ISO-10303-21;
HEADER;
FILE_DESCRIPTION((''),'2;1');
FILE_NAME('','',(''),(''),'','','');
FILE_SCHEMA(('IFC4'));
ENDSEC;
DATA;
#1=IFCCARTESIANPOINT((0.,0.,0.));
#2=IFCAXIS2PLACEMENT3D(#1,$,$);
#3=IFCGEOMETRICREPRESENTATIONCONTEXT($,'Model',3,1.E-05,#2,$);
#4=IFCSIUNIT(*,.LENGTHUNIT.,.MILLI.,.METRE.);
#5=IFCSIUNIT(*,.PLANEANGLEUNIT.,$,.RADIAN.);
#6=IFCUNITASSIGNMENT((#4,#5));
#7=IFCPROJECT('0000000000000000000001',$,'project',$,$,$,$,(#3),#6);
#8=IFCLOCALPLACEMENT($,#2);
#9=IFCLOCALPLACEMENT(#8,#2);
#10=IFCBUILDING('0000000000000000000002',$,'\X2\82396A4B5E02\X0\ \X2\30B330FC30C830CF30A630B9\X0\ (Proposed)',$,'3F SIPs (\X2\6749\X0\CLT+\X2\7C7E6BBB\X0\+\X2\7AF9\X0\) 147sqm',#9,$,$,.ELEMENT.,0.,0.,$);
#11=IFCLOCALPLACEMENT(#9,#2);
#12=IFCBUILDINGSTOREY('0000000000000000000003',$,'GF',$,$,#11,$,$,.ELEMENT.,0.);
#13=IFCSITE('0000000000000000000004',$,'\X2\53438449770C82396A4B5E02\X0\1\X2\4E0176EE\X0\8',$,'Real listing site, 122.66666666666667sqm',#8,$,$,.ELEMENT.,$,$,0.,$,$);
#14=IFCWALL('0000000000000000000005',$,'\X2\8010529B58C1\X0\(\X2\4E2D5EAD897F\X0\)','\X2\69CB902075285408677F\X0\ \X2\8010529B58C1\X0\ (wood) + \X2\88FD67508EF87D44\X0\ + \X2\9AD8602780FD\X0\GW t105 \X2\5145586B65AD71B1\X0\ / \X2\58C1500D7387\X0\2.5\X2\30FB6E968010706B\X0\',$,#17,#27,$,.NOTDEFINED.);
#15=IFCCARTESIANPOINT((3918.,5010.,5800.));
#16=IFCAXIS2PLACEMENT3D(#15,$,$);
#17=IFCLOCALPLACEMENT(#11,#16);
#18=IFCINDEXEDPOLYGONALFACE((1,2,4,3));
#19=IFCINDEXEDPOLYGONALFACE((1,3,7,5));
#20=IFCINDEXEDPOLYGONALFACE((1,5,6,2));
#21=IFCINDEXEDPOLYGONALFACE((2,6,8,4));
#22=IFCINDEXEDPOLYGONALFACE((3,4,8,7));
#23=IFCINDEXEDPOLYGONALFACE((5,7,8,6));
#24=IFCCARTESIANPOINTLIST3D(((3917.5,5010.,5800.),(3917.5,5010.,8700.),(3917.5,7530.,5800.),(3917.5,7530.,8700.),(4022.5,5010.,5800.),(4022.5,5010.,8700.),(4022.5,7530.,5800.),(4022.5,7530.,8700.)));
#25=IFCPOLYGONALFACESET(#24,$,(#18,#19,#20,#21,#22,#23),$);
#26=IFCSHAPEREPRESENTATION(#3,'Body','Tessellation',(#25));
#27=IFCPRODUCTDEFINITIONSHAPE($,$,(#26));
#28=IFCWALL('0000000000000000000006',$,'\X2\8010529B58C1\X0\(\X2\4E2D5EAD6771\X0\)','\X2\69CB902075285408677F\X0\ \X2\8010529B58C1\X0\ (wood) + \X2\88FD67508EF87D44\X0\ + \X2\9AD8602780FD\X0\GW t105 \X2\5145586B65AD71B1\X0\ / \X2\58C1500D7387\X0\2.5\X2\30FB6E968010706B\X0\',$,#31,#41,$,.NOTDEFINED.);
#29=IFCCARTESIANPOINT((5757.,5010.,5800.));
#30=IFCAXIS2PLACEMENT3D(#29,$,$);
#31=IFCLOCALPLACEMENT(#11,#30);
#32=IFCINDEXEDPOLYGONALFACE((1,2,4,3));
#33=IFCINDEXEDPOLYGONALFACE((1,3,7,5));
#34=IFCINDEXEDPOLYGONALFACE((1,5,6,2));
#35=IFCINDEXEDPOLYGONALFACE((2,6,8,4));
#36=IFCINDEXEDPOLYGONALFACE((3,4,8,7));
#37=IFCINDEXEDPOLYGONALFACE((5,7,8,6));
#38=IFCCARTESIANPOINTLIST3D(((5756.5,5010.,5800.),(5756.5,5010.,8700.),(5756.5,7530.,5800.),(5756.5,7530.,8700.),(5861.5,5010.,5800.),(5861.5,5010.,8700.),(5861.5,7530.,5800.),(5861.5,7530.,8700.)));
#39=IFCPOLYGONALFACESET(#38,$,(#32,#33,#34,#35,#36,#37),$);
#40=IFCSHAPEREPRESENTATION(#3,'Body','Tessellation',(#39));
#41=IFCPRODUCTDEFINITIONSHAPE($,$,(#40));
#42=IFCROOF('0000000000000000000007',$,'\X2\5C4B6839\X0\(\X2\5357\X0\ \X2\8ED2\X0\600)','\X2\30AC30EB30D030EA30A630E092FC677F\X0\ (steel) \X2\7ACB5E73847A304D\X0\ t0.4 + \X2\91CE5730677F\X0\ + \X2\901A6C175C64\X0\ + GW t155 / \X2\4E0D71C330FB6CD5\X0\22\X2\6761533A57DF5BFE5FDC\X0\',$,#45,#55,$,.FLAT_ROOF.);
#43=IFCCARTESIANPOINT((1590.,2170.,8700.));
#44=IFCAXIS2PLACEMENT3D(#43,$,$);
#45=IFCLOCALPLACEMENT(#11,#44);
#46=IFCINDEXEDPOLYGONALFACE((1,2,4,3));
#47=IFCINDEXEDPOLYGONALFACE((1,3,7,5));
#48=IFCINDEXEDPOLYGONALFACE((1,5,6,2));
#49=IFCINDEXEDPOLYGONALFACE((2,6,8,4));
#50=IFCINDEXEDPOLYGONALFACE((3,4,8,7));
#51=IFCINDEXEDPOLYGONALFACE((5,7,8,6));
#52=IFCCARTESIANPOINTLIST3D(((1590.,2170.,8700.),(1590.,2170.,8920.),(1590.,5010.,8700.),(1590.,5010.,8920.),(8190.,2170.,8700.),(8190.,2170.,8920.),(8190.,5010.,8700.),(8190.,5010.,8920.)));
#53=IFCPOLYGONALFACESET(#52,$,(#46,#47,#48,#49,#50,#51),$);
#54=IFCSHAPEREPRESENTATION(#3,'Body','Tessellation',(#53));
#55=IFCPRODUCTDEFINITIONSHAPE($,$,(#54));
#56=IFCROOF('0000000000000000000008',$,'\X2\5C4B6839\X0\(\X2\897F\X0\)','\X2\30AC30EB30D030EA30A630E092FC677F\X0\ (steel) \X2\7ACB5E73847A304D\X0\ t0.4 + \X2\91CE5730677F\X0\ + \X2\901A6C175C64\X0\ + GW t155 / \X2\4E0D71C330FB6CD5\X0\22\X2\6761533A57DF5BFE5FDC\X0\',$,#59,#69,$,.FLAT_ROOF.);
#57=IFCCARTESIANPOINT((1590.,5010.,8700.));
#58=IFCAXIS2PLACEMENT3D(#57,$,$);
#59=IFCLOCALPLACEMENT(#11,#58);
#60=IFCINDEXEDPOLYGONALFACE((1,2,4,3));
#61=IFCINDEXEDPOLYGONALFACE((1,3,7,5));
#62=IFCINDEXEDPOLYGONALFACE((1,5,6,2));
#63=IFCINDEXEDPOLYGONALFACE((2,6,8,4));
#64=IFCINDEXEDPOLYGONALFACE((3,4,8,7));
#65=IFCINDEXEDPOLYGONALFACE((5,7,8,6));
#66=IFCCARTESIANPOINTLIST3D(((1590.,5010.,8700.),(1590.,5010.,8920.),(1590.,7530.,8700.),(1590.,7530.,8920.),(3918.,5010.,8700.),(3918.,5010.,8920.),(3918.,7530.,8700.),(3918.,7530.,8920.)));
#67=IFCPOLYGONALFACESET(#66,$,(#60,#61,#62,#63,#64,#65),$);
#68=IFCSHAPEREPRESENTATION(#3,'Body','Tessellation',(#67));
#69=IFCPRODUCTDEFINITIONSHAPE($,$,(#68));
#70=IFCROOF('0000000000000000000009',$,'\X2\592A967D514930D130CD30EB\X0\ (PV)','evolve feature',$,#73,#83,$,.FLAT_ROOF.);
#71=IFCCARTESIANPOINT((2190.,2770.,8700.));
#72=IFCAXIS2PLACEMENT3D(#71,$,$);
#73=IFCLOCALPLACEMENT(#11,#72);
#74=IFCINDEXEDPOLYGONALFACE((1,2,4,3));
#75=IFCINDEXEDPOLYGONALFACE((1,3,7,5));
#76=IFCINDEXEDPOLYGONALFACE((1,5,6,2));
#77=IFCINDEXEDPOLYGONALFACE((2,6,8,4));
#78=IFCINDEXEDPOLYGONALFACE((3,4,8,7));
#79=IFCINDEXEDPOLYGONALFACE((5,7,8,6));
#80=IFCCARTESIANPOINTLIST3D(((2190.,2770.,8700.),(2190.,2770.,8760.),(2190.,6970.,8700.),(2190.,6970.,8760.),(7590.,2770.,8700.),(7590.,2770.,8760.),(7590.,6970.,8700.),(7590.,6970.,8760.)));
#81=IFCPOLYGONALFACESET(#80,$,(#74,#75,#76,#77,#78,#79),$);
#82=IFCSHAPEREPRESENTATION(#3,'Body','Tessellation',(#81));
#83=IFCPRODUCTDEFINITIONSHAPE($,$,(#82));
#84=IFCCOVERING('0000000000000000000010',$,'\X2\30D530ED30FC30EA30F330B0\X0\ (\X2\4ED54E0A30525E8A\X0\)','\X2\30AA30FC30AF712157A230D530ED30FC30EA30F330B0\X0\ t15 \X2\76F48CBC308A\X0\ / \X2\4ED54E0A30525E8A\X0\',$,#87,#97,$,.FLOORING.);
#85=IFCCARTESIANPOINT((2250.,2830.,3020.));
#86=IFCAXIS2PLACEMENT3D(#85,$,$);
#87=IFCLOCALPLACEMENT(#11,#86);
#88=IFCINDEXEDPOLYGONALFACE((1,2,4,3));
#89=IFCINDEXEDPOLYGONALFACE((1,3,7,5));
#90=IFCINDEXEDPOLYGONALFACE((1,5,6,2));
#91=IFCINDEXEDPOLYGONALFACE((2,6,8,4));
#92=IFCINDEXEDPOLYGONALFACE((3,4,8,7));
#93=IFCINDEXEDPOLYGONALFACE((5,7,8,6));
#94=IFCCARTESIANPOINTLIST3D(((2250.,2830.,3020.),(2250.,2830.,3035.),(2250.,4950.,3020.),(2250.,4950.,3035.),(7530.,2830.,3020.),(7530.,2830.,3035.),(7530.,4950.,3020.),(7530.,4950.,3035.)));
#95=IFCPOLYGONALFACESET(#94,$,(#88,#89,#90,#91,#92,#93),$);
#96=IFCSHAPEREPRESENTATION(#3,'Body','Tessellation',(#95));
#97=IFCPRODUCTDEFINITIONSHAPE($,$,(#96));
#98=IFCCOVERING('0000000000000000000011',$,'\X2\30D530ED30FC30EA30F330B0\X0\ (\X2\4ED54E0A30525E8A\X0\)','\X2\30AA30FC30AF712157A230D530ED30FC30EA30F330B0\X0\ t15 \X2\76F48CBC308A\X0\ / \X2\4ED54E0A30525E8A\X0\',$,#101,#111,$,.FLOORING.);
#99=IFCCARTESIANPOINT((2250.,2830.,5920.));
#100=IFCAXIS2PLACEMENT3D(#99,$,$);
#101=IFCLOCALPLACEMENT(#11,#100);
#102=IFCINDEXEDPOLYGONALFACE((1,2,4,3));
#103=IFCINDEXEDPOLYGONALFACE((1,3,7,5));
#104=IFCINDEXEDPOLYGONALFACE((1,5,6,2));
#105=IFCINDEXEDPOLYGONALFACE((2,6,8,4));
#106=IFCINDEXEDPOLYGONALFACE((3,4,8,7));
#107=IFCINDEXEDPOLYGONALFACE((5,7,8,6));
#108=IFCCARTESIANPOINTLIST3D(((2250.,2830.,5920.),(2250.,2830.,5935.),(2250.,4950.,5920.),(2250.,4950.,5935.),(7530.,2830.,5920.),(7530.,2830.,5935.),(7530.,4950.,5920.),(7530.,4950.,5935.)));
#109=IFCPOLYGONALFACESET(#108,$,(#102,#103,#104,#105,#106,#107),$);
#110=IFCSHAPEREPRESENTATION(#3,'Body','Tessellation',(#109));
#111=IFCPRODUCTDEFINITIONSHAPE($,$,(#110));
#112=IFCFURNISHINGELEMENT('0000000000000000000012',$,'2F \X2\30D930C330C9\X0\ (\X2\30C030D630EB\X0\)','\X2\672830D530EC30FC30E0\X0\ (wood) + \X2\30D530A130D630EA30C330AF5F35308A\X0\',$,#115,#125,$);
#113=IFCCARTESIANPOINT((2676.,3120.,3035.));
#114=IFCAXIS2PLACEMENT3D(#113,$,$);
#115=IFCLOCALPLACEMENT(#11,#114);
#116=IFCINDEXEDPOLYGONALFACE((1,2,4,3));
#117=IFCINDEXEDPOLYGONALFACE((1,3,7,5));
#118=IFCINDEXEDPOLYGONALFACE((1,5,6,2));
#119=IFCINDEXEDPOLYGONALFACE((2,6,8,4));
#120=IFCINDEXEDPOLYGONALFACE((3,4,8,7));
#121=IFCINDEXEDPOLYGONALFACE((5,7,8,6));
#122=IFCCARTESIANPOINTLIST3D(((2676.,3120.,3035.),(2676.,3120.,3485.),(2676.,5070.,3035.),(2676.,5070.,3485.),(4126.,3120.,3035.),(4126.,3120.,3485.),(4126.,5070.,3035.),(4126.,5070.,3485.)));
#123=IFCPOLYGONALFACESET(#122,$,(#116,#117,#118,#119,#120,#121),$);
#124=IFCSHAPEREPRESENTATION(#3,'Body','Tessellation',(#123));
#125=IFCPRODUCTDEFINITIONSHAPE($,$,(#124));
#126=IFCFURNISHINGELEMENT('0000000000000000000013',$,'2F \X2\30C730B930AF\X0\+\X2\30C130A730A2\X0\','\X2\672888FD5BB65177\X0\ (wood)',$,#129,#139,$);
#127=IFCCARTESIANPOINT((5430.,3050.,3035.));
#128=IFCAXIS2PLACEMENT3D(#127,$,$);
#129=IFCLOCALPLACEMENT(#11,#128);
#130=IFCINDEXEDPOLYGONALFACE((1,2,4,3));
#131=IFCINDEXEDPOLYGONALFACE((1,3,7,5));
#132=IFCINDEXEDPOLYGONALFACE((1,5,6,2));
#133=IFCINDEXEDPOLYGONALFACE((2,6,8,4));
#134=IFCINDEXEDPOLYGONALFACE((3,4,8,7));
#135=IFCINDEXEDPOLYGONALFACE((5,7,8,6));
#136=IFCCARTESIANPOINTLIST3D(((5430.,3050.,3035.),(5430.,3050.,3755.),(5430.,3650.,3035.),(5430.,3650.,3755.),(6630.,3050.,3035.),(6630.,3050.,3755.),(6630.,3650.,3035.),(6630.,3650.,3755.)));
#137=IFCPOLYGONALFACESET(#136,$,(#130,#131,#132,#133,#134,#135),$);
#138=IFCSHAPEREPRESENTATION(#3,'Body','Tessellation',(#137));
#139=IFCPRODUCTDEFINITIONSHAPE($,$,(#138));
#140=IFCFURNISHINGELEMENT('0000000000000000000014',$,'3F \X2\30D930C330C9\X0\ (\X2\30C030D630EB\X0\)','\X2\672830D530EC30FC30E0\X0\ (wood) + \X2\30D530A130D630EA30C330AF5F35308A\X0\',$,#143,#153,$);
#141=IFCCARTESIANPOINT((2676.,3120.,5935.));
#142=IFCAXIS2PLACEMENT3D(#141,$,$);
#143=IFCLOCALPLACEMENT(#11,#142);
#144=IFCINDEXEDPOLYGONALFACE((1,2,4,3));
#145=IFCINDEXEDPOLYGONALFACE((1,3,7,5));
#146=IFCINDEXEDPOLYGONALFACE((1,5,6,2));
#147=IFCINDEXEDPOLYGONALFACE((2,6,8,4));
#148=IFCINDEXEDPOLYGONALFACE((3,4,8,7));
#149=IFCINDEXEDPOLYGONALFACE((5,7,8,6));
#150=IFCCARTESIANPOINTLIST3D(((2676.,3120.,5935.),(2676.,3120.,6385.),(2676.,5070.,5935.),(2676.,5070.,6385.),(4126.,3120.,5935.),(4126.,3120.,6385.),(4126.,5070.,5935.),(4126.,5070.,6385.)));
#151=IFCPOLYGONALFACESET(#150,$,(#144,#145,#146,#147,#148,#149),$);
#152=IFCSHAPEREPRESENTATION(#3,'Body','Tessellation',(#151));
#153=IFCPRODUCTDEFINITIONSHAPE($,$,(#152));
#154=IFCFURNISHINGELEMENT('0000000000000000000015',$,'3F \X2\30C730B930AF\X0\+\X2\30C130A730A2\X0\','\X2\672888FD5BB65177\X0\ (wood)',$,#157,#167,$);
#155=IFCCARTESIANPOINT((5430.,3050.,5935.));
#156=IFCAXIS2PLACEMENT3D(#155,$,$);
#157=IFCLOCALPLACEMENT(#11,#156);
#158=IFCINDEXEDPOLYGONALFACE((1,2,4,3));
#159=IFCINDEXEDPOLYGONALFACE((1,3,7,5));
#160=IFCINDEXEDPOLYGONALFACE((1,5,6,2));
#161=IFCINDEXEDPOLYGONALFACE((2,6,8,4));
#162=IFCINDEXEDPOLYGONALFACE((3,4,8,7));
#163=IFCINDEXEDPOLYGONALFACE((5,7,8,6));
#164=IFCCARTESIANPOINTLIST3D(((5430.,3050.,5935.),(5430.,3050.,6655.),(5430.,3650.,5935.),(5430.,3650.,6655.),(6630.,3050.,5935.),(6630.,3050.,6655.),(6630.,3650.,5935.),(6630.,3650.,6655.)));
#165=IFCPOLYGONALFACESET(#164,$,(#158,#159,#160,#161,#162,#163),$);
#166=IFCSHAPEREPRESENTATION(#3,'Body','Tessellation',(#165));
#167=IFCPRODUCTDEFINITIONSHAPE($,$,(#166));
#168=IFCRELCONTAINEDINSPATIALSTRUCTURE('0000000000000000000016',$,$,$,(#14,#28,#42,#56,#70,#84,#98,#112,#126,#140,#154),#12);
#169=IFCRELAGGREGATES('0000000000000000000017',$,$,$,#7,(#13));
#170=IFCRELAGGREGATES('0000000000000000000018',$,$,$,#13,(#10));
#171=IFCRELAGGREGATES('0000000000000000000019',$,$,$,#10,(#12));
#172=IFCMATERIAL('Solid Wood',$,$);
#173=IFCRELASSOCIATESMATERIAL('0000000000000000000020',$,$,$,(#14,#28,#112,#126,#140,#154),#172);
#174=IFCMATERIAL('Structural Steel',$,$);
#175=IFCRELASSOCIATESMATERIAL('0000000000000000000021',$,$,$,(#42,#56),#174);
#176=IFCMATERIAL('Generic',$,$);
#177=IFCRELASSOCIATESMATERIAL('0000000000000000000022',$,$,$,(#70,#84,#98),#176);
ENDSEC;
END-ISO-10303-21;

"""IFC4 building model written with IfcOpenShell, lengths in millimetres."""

from ifc_helpers import new_model, si_unit, frame, frame_2d, origin, place, context, project, spatial, rectangle, extrude, material, element, save


model = new_model("IFC4")

# Units and contexts
model_context = context("Model", 3, precision=1e-05, world=origin())
ifc_project = project(units=[si_unit("LENGTHUNIT", "METRE", prefix="MILLI"), si_unit("PLANEANGLEUNIT", "RADIAN")], contexts=[model_context])

# Site, building, storey
site_placement = place(None, origin())
site = spatial("IfcSite", under=ifc_project, at=site_placement, Name="千葉県船橋市1丁目8", ObjectType="Real listing site, 122.66666666666667sqm", CompositionType="ELEMENT", RefElevation=0.0)
building_placement = place(site_placement, origin())
building = spatial("IfcBuilding", under=site, at=building_placement, Name="船橋市 コートハウス (Proposed)", ObjectType="3F SIPs (杉CLT+籾殻+竹) 147sqm", CompositionType="ELEMENT", ElevationOfRefHeight=0.0, ElevationOfTerrain=0.0)
storey_placement = place(building_placement, origin())
storey = spatial("IfcBuildingStorey", under=building, at=storey_placement, Name="GF", CompositionType="ELEMENT", Elevation=0.0)

# Shared definitions
ifc_material_1 = material(Name="Solid Wood")

# Walls
wall_1_placement = place(storey_placement, frame((3918.0, 5010.0, 5800.0)))
element("IfcWall", 1, at=wall_1_placement, inside=storey, material=ifc_material_1, Name="耐力壁(中庭西)", Description="構造用合板 耐力壁 (wood) + 製材軸組 + 高性能GW t105 充填断熱 / 壁倍率2.5・準耐火", PredefinedType="NOTDEFINED", context=model_context, shape_type="SweptSolid", body=[
    extrude(rectangle(XDim=105.0, YDim=2520.0, at=frame_2d((52.0, 1260.0))), frame((3918.0, 5010.0, 5800.0)), (0.0, 0.0, 1.0), 2900.0),
])
wall_2_placement = place(storey_placement, frame((5757.0, 5010.0, 5800.0)))
element("IfcWall", 2, at=wall_2_placement, inside=storey, material=ifc_material_1, Name="耐力壁(中庭東)", Description="構造用合板 耐力壁 (wood) + 製材軸組 + 高性能GW t105 充填断熱 / 壁倍率2.5・準耐火", PredefinedType="NOTDEFINED", context=model_context, shape_type="SweptSolid", body=[
    extrude(rectangle(XDim=105.0, YDim=2520.0, at=frame_2d((52.0, 1260.0))), frame((5757.0, 5010.0, 5800.0)), (0.0, 0.0, 1.0), 2900.0),
])

# Roofs
ifc_material_2 = material(Name="Structural Steel")
roof_1_placement = place(storey_placement, frame((1590.0, 2170.0, 8700.0)))
element("IfcRoof", 3, at=roof_1_placement, inside=storey, material=ifc_material_2, Name="屋根(南 軒600)", Description="ガルバリウム鋼板 (steel) 立平葺き t0.4 + 野地板 + 通気層 + GW t155 / 不燃・法22条区域対応", PredefinedType="FLAT_ROOF", context=model_context, shape_type="SweptSolid", body=[
    extrude(rectangle(XDim=6600.0, YDim=2840.0, at=frame_2d((3300.0, 1420.0))), frame((1590.0, 2170.0, 8700.0)), (0.0, 0.0, 1.0), 220.0),
])
roof_2_placement = place(storey_placement, frame((1590.0, 5010.0, 8700.0)))
element("IfcRoof", 4, at=roof_2_placement, inside=storey, material=ifc_material_2, Name="屋根(西)", Description="ガルバリウム鋼板 (steel) 立平葺き t0.4 + 野地板 + 通気層 + GW t155 / 不燃・法22条区域対応", PredefinedType="FLAT_ROOF", context=model_context, shape_type="SweptSolid", body=[
    extrude(rectangle(XDim=2328.0, YDim=2520.0, at=frame_2d((1164.0, 1260.0))), frame((1590.0, 5010.0, 8700.0)), (0.0, 0.0, 1.0), 220.0),
])
ifc_material_3 = material(Name="Generic")
roof_3_placement = place(storey_placement, frame((2190.0, 2770.0, 8700.0)))
element("IfcRoof", 5, at=roof_3_placement, inside=storey, material=ifc_material_3, Name="太陽光パネル (PV)", Description="evolve feature", PredefinedType="FLAT_ROOF", context=model_context, shape_type="SweptSolid", body=[
    extrude(rectangle(XDim=5400.0, YDim=4200.0, at=frame_2d((2700.0, 2100.0))), frame((2190.0, 2770.0, 8700.0)), (0.0, 0.0, 1.0), 60.0),
])

# Coverings
covering_1_placement = place(storey_placement, frame((2250.0, 2830.0, 3020.0)))
element("IfcCovering", 6, at=covering_1_placement, inside=storey, material=ifc_material_3, Name="フローリング (仕上げ床)", Description="オーク無垢フローリング t15 直貼り / 仕上げ床", PredefinedType="FLOORING", context=model_context, shape_type="SweptSolid", body=[
    extrude(rectangle(XDim=5280.0, YDim=2120.0, at=frame_2d((2640.0, 1060.0))), frame((2250.0, 2830.0, 3020.0)), (0.0, 0.0, 1.0), 15.0),
])
covering_2_placement = place(storey_placement, frame((2250.0, 2830.0, 5920.0)))
element("IfcCovering", 7, at=covering_2_placement, inside=storey, material=ifc_material_3, Name="フローリング (仕上げ床)", Description="オーク無垢フローリング t15 直貼り / 仕上げ床", PredefinedType="FLOORING", context=model_context, shape_type="SweptSolid", body=[
    extrude(rectangle(XDim=5280.0, YDim=2120.0, at=frame_2d((2640.0, 1060.0))), frame((2250.0, 2830.0, 5920.0)), (0.0, 0.0, 1.0), 15.0),
])

# Furnishing elements
furnishing_1_placement = place(storey_placement, frame((2676.0, 3120.0, 3035.0)))
element("IfcFurnishingElement", 8, at=furnishing_1_placement, inside=storey, material=ifc_material_1, Name="2F ベッド (ダブル)", Description="木フレーム (wood) + ファブリック張り", context=model_context, shape_type="SweptSolid", body=[
    extrude(rectangle(XDim=1450.0, YDim=1950.0, at=frame_2d((725.0, 975.0))), frame((2676.0, 3120.0, 3035.0)), (0.0, 0.0, 1.0), 450.0),
])
furnishing_2_placement = place(storey_placement, frame((5430.0, 3050.0, 3035.0)))
element("IfcFurnishingElement", 9, at=furnishing_2_placement, inside=storey, material=ifc_material_1, Name="2F デスク+チェア", Description="木製家具 (wood)", context=model_context, shape_type="SweptSolid", body=[
    extrude(rectangle(XDim=1200.0, YDim=600.0, at=frame_2d((600.0, 300.0))), frame((5430.0, 3050.0, 3035.0)), (0.0, 0.0, 1.0), 720.0),
])
furnishing_3_placement = place(storey_placement, frame((2676.0, 3120.0, 5935.0)))
element("IfcFurnishingElement", 10, at=furnishing_3_placement, inside=storey, material=ifc_material_1, Name="3F ベッド (ダブル)", Description="木フレーム (wood) + ファブリック張り", context=model_context, shape_type="SweptSolid", body=[
    extrude(rectangle(XDim=1450.0, YDim=1950.0, at=frame_2d((725.0, 975.0))), frame((2676.0, 3120.0, 5935.0)), (0.0, 0.0, 1.0), 450.0),
])
furnishing_4_placement = place(storey_placement, frame((5430.0, 3050.0, 5935.0)))
element("IfcFurnishingElement", 11, at=furnishing_4_placement, inside=storey, material=ifc_material_1, Name="3F デスク+チェア", Description="木製家具 (wood)", context=model_context, shape_type="SweptSolid", body=[
    extrude(rectangle(XDim=1200.0, YDim=600.0, at=frame_2d((600.0, 300.0))), frame((5430.0, 3050.0, 5935.0)), (0.0, 0.0, 1.0), 720.0),
])

save(model, "model.ifc")
